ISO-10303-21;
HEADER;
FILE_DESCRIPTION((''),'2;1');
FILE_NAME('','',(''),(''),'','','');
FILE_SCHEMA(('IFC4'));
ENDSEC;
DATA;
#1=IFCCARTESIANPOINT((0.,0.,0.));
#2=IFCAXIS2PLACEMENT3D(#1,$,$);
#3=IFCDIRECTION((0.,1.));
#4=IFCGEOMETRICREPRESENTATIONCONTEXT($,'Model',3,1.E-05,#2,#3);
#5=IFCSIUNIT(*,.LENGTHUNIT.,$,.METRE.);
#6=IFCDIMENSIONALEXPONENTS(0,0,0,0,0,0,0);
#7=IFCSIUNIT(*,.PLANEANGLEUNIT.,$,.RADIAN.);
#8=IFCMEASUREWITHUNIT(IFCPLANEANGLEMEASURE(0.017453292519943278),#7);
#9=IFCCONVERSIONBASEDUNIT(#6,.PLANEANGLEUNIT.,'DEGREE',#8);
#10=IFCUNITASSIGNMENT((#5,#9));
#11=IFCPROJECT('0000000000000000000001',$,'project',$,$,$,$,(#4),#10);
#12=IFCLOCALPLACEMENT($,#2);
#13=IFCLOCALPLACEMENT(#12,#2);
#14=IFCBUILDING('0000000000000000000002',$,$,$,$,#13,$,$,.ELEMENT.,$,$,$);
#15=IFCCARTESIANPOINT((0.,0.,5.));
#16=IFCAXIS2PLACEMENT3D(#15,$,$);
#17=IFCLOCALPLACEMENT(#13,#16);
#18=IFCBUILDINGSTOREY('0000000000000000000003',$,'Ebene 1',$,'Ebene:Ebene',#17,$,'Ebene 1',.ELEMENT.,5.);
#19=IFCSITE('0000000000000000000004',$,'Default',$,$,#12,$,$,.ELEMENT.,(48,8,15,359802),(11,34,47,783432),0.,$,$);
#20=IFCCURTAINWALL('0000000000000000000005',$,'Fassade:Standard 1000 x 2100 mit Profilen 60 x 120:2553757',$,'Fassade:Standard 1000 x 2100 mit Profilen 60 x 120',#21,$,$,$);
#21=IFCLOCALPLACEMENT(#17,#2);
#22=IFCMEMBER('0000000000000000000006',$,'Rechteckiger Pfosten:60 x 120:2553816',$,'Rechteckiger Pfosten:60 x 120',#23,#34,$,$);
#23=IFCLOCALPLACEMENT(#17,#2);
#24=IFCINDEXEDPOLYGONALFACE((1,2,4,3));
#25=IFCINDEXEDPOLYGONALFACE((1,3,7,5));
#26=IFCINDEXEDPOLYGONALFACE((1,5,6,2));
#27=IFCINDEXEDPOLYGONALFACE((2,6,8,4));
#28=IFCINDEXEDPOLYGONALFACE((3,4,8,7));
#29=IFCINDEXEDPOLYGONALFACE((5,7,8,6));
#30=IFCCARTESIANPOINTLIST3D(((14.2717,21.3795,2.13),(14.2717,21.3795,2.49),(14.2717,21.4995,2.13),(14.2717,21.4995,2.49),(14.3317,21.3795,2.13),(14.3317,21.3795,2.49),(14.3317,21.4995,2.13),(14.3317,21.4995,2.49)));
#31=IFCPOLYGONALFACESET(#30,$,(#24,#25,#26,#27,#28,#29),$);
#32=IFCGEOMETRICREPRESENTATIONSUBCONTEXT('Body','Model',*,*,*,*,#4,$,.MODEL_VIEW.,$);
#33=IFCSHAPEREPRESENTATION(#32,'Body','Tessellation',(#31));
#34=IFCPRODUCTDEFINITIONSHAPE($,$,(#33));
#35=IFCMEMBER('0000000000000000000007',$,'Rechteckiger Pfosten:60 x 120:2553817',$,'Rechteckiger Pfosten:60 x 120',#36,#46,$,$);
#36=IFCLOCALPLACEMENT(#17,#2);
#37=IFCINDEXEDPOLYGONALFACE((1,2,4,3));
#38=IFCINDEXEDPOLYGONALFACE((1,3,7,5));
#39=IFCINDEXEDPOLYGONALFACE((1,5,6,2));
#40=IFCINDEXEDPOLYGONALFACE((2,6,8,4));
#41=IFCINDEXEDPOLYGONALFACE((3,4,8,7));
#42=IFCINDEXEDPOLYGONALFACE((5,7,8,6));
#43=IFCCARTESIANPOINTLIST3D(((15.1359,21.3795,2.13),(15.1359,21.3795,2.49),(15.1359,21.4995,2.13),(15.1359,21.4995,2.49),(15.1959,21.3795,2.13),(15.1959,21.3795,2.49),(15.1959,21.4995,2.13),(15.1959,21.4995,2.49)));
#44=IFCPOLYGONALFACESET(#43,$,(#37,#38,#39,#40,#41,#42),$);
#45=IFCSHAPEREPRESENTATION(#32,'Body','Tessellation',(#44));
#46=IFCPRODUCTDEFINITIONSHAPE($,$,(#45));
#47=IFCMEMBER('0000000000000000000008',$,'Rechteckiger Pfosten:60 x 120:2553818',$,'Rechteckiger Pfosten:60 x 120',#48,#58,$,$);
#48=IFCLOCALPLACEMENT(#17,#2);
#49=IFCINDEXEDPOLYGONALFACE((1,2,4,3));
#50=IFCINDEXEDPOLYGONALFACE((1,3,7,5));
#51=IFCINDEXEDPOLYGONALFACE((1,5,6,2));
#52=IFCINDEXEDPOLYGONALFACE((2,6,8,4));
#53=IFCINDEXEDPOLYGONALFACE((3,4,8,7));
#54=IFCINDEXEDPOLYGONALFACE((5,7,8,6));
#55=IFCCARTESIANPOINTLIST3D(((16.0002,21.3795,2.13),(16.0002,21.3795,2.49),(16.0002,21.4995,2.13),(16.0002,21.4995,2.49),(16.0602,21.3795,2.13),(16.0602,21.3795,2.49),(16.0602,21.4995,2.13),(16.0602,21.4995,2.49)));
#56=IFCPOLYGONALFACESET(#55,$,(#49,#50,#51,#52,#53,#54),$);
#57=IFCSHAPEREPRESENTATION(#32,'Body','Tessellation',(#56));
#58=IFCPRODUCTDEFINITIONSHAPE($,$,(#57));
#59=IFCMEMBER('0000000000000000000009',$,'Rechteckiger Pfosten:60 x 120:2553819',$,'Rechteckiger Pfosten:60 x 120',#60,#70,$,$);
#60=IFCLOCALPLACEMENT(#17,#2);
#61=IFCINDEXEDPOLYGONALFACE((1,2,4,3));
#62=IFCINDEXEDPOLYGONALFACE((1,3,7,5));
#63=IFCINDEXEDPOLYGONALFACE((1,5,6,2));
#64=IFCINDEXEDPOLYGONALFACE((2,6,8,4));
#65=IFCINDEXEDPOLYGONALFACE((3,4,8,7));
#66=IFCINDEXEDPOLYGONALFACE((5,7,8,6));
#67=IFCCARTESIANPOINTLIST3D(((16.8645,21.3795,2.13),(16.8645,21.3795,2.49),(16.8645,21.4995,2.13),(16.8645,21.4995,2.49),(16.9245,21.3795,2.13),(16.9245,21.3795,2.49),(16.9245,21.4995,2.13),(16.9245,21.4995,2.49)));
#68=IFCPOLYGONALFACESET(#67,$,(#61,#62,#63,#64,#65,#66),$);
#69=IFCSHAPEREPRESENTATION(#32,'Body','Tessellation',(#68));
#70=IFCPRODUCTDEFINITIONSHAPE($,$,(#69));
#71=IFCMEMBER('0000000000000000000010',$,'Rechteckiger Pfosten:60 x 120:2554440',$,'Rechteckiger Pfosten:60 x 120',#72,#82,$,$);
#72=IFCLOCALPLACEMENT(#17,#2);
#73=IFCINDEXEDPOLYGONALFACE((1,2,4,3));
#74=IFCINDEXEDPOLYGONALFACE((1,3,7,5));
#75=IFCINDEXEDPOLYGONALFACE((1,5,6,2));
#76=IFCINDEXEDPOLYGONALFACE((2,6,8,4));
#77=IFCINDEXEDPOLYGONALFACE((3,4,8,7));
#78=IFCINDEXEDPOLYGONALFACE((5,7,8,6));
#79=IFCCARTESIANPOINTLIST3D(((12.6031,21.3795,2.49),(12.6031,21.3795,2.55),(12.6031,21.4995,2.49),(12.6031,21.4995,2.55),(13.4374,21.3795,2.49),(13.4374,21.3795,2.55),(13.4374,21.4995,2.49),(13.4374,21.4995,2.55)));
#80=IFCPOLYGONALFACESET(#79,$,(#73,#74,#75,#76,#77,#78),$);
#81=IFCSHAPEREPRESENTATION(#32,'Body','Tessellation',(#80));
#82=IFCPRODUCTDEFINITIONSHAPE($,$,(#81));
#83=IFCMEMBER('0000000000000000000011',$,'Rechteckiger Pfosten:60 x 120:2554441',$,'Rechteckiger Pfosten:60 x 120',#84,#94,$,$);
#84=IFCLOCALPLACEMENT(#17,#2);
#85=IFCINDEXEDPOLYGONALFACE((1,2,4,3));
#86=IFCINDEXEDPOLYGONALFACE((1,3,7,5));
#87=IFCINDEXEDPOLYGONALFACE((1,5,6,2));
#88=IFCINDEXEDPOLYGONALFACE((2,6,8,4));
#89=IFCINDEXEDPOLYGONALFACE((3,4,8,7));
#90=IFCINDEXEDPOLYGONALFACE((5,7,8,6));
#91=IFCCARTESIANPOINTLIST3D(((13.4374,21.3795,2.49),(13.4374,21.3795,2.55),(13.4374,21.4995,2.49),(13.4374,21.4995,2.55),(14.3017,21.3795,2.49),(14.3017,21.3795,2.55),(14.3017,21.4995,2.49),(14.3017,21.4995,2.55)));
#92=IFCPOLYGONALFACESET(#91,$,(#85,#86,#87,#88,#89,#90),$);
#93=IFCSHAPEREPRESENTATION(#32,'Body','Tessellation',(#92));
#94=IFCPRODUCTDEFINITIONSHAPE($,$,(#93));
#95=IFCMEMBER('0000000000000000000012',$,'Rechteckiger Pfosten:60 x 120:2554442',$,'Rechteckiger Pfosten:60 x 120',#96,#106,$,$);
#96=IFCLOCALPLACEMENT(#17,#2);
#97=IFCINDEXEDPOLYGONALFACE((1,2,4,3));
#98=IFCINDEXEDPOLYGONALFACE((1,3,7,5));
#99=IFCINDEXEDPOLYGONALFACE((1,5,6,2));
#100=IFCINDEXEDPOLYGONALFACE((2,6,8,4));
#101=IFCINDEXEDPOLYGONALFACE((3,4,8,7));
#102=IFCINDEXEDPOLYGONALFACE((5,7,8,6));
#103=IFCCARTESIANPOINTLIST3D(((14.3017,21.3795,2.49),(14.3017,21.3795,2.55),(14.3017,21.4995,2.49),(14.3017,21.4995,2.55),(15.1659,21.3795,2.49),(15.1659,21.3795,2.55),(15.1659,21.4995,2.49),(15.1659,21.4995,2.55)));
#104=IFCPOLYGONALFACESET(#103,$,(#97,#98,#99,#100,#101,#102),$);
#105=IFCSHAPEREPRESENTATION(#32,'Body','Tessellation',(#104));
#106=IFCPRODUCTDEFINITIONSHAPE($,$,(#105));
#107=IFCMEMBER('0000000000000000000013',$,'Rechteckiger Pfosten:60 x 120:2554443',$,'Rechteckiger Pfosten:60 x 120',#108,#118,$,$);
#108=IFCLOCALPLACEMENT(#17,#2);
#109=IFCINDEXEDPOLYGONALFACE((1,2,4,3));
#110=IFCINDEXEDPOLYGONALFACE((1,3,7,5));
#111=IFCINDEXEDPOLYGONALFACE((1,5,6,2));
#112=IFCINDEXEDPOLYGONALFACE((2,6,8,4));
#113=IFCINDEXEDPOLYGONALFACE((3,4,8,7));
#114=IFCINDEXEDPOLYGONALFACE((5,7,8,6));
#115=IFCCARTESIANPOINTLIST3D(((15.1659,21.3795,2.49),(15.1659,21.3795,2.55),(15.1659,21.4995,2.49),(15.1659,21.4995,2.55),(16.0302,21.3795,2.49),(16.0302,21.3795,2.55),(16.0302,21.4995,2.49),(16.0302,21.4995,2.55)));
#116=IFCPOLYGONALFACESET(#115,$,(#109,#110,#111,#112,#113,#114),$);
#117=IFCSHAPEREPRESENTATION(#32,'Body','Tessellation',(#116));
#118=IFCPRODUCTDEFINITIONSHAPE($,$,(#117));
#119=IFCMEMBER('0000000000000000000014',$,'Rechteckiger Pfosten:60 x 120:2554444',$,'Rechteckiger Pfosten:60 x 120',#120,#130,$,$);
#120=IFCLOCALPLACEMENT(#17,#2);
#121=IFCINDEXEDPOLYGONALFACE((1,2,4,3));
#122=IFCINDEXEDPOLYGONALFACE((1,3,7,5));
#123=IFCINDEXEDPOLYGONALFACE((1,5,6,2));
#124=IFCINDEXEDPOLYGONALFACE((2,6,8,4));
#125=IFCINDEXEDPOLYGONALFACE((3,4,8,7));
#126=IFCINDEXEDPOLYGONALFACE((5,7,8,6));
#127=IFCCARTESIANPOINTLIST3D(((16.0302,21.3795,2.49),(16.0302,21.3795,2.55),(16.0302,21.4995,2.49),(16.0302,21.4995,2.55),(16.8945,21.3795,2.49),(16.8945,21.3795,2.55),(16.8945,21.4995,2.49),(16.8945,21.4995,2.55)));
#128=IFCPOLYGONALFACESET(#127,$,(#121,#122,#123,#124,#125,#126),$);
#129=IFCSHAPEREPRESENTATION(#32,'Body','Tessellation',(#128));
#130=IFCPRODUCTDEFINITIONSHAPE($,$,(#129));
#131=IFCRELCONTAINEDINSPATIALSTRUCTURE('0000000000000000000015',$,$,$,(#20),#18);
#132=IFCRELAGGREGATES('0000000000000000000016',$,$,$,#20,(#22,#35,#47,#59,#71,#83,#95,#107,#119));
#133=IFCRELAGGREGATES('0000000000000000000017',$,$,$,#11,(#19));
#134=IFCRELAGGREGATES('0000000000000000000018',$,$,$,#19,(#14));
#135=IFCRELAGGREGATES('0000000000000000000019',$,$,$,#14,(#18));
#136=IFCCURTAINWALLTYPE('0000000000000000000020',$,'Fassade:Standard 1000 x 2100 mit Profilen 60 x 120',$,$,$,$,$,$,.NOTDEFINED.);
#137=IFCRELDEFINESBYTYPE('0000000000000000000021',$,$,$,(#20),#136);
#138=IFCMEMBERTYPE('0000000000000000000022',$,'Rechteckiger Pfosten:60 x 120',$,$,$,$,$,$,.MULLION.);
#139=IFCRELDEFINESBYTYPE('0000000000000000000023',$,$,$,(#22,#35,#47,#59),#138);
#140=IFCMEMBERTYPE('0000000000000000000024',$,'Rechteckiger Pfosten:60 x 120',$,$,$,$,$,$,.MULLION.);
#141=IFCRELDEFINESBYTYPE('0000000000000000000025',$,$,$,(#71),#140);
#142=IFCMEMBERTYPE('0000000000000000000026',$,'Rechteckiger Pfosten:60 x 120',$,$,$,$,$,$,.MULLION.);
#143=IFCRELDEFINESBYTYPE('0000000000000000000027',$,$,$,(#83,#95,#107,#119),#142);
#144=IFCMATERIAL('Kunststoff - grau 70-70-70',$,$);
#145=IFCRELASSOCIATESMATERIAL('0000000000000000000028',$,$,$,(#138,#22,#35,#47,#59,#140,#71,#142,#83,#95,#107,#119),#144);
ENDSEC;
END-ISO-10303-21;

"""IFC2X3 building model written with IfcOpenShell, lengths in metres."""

from ifc_helpers import new_model, entity, si_unit, converted_unit, direction, frame, frame_2d, origin, origin_2d_with_axis, place, context, subcontext, project, spatial, rectangle, extrude, source, transform, mapped, material, type_object, type_shapes, element, aggregate, save


model = new_model("IFC2X3")

# Units and contexts
model_context = context("Model", 3, precision=1e-05, world=origin(), true_north=direction((0.0, 1.0)))
body_context = subcontext(model_context, "Body", "Model", "MODEL_VIEW")
ifc_project = project(units=[si_unit("LENGTHUNIT", "METRE"), converted_unit("PLANEANGLEUNIT", "DEGREE", entity("IfcPlaneAngleMeasure", 0.017453292519943278), si_unit("PLANEANGLEUNIT", "RADIAN"), dimensions=[0, 0, 0, 0, 0, 0, 0])], contexts=[model_context])

# Site, building, storey
site_placement = place(None, origin())
site = spatial("IfcSite", under=ifc_project, at=site_placement, Name="Default", CompositionType="ELEMENT", RefLatitude=(48, 8, 15, 359802), RefLongitude=(11, 34, 47, 783432), RefElevation=0.0)
building_placement = place(site_placement, origin())
building = spatial("IfcBuilding", under=site, at=building_placement, CompositionType="ELEMENT")
storey_placement = place(building_placement, frame((0.0, 0.0, 5.0)))
storey = spatial("IfcBuildingStorey", under=building, at=storey_placement, Name="Ebene 1", ObjectType="Ebene:Ebene", LongName="Ebene 1", CompositionType="ELEMENT", Elevation=5.0)

# Curtain wall, members
curtain_wall_type = type_object("IfcCurtainWallType", Name="Fassade:Standard 1000 x 2100 mit Profilen 60 x 120", PredefinedType="NOTDEFINED")
curtain_wall_placement = place(storey_placement, frame((0.0, 0.0, -5.0)))
curtain_wall = element("IfcCurtainWall", 1, at=curtain_wall_placement, inside=storey, type_object=curtain_wall_type, Name="Fassade:Standard 1000 x 2100 mit Profilen 60 x 120:2553757", ObjectType="Fassade:Standard 1000 x 2100 mit Profilen 60 x 120")
ifc_material_1 = material(Name="Kunststoff - grau 70-70-70")
member_type_1 = type_object("IfcMemberType", Name="Rechteckiger Pfosten:60 x 120", PredefinedType="MULLION", material=ifc_material_1)
shared_shape_1 = source(origin(), body_context, "Body", "SweptSolid", [
    extrude(rectangle(XDim=0.06, YDim=0.12, at=frame_2d((0.0, 0.0), x_axis=(1.0, 0.0))), frame((0.0, 0.0, -0.36), z_axis=(0.0, 0.0, 1.0), x_axis=(-1.0, 0.0, 0.0)), (0.0, 0.0, 1.0), 0.36),
])
type_shapes(member_type_1, [shared_shape_1])
member_1_placement = place(curtain_wall_placement, frame((14.3017, 21.4395, 7.13), z_axis=(0.0, 0.0, -1.0), x_axis=(1.0, 0.0, 0.0)))
member_1 = element("IfcMember", 2, at=member_1_placement, type_object=member_type_1, material=ifc_material_1, Name="Rechteckiger Pfosten:60 x 120:2553816", ObjectType="Rechteckiger Pfosten:60 x 120", context=body_context, shape_type="MappedRepresentation", body=[
    mapped(shared_shape_1, transform((0.0, 0.0, 0.0), scale=1.0)),
])
member_2_placement = place(curtain_wall_placement, frame((15.1659, 21.4395, 7.13), z_axis=(0.0, 0.0, -1.0), x_axis=(1.0, 0.0, 0.0)))
member_2 = element("IfcMember", 3, at=member_2_placement, type_object=member_type_1, material=ifc_material_1, Name="Rechteckiger Pfosten:60 x 120:2553817", ObjectType="Rechteckiger Pfosten:60 x 120", context=body_context, shape_type="MappedRepresentation", body=[
    mapped(shared_shape_1, transform((0.0, 0.0, 0.0), scale=1.0)),
])
member_3_placement = place(curtain_wall_placement, frame((16.0302, 21.4395, 7.13), z_axis=(0.0, 0.0, -1.0), x_axis=(1.0, 0.0, 0.0)))
member_3 = element("IfcMember", 4, at=member_3_placement, type_object=member_type_1, material=ifc_material_1, Name="Rechteckiger Pfosten:60 x 120:2553818", ObjectType="Rechteckiger Pfosten:60 x 120", context=body_context, shape_type="MappedRepresentation", body=[
    mapped(shared_shape_1, transform((0.0, 0.0, 0.0), scale=1.0)),
])
member_4_placement = place(curtain_wall_placement, frame((16.8945, 21.4395, 7.13), z_axis=(0.0, 0.0, -1.0), x_axis=(1.0, 0.0, 0.0)))
member_4 = element("IfcMember", 5, at=member_4_placement, type_object=member_type_1, material=ifc_material_1, Name="Rechteckiger Pfosten:60 x 120:2553819", ObjectType="Rechteckiger Pfosten:60 x 120", context=body_context, shape_type="MappedRepresentation", body=[
    mapped(shared_shape_1, transform((0.0, 0.0, 0.0), scale=1.0)),
])
member_type_2 = type_object("IfcMemberType", Name="Rechteckiger Pfosten:60 x 120", PredefinedType="MULLION", material=ifc_material_1)
shared_shape_2 = source(origin(), body_context, "Body", "SweptSolid", [
    extrude(rectangle(XDim=0.06, YDim=0.12, at=origin_2d_with_axis()), frame((-0.03, 0.0, -0.8343), z_axis=(0.0, 0.0, 1.0), x_axis=(-1.0, 0.0, 0.0)), (0.0, 0.0, 1.0), 0.8343),
])
type_shapes(member_type_2, [shared_shape_2])
member_5_placement = place(curtain_wall_placement, frame((13.4374, 21.4395, 7.55), z_axis=(1.0, 0.0, 0.0), x_axis=(0.0, 0.0, 1.0)))
member_5 = element("IfcMember", 6, at=member_5_placement, type_object=member_type_2, material=ifc_material_1, Name="Rechteckiger Pfosten:60 x 120:2554440", ObjectType="Rechteckiger Pfosten:60 x 120", context=body_context, shape_type="MappedRepresentation", body=[
    mapped(shared_shape_2, transform((0.0, 0.0, 0.0), scale=1.0)),
])
member_type_3 = type_object("IfcMemberType", Name="Rechteckiger Pfosten:60 x 120", PredefinedType="MULLION", material=ifc_material_1)
shared_shape_3 = source(origin(), body_context, "Body", "SweptSolid", [
    extrude(rectangle(XDim=0.06, YDim=0.12, at=origin_2d_with_axis()), frame((-0.03, 0.0, -0.8643), z_axis=(0.0, 0.0, 1.0), x_axis=(-1.0, 0.0, 0.0)), (0.0, 0.0, 1.0), 0.8643),
])
type_shapes(member_type_3, [shared_shape_3])
member_6_placement = place(curtain_wall_placement, frame((14.3017, 21.4395, 7.55), z_axis=(1.0, 0.0, 0.0), x_axis=(0.0, 0.0, 1.0)))
member_6 = element("IfcMember", 7, at=member_6_placement, type_object=member_type_3, material=ifc_material_1, Name="Rechteckiger Pfosten:60 x 120:2554441", ObjectType="Rechteckiger Pfosten:60 x 120", context=body_context, shape_type="MappedRepresentation", body=[
    mapped(shared_shape_3, transform((0.0, 0.0, 0.0), scale=1.0)),
])
member_7_placement = place(curtain_wall_placement, frame((15.1659, 21.4395, 7.55), z_axis=(1.0, 0.0, 0.0), x_axis=(0.0, 0.0, 1.0)))
member_7 = element("IfcMember", 8, at=member_7_placement, type_object=member_type_3, material=ifc_material_1, Name="Rechteckiger Pfosten:60 x 120:2554442", ObjectType="Rechteckiger Pfosten:60 x 120", context=body_context, shape_type="MappedRepresentation", body=[
    mapped(shared_shape_3, transform((0.0, 0.0, 0.0), scale=1.0)),
])
member_8_placement = place(curtain_wall_placement, frame((16.0302, 21.4395, 7.55), z_axis=(1.0, 0.0, 0.0), x_axis=(0.0, 0.0, 1.0)))
member_8 = element("IfcMember", 9, at=member_8_placement, type_object=member_type_3, material=ifc_material_1, Name="Rechteckiger Pfosten:60 x 120:2554443", ObjectType="Rechteckiger Pfosten:60 x 120", context=body_context, shape_type="MappedRepresentation", body=[
    mapped(shared_shape_3, transform((0.0, 0.0, 0.0), scale=1.0)),
])
member_9_placement = place(curtain_wall_placement, frame((16.8945, 21.4395, 7.55), z_axis=(1.0, 0.0, 0.0), x_axis=(0.0, 0.0, 1.0)))
member_9 = element("IfcMember", 10, at=member_9_placement, type_object=member_type_3, material=ifc_material_1, Name="Rechteckiger Pfosten:60 x 120:2554444", ObjectType="Rechteckiger Pfosten:60 x 120", context=body_context, shape_type="MappedRepresentation", body=[
    mapped(shared_shape_3, transform((0.0, 0.0, 0.0), scale=1.0)),
])
aggregate(curtain_wall, [member_1, member_2, member_3, member_4, member_5, member_6, member_7, member_8, member_9])

save(model, "model.ifc")
